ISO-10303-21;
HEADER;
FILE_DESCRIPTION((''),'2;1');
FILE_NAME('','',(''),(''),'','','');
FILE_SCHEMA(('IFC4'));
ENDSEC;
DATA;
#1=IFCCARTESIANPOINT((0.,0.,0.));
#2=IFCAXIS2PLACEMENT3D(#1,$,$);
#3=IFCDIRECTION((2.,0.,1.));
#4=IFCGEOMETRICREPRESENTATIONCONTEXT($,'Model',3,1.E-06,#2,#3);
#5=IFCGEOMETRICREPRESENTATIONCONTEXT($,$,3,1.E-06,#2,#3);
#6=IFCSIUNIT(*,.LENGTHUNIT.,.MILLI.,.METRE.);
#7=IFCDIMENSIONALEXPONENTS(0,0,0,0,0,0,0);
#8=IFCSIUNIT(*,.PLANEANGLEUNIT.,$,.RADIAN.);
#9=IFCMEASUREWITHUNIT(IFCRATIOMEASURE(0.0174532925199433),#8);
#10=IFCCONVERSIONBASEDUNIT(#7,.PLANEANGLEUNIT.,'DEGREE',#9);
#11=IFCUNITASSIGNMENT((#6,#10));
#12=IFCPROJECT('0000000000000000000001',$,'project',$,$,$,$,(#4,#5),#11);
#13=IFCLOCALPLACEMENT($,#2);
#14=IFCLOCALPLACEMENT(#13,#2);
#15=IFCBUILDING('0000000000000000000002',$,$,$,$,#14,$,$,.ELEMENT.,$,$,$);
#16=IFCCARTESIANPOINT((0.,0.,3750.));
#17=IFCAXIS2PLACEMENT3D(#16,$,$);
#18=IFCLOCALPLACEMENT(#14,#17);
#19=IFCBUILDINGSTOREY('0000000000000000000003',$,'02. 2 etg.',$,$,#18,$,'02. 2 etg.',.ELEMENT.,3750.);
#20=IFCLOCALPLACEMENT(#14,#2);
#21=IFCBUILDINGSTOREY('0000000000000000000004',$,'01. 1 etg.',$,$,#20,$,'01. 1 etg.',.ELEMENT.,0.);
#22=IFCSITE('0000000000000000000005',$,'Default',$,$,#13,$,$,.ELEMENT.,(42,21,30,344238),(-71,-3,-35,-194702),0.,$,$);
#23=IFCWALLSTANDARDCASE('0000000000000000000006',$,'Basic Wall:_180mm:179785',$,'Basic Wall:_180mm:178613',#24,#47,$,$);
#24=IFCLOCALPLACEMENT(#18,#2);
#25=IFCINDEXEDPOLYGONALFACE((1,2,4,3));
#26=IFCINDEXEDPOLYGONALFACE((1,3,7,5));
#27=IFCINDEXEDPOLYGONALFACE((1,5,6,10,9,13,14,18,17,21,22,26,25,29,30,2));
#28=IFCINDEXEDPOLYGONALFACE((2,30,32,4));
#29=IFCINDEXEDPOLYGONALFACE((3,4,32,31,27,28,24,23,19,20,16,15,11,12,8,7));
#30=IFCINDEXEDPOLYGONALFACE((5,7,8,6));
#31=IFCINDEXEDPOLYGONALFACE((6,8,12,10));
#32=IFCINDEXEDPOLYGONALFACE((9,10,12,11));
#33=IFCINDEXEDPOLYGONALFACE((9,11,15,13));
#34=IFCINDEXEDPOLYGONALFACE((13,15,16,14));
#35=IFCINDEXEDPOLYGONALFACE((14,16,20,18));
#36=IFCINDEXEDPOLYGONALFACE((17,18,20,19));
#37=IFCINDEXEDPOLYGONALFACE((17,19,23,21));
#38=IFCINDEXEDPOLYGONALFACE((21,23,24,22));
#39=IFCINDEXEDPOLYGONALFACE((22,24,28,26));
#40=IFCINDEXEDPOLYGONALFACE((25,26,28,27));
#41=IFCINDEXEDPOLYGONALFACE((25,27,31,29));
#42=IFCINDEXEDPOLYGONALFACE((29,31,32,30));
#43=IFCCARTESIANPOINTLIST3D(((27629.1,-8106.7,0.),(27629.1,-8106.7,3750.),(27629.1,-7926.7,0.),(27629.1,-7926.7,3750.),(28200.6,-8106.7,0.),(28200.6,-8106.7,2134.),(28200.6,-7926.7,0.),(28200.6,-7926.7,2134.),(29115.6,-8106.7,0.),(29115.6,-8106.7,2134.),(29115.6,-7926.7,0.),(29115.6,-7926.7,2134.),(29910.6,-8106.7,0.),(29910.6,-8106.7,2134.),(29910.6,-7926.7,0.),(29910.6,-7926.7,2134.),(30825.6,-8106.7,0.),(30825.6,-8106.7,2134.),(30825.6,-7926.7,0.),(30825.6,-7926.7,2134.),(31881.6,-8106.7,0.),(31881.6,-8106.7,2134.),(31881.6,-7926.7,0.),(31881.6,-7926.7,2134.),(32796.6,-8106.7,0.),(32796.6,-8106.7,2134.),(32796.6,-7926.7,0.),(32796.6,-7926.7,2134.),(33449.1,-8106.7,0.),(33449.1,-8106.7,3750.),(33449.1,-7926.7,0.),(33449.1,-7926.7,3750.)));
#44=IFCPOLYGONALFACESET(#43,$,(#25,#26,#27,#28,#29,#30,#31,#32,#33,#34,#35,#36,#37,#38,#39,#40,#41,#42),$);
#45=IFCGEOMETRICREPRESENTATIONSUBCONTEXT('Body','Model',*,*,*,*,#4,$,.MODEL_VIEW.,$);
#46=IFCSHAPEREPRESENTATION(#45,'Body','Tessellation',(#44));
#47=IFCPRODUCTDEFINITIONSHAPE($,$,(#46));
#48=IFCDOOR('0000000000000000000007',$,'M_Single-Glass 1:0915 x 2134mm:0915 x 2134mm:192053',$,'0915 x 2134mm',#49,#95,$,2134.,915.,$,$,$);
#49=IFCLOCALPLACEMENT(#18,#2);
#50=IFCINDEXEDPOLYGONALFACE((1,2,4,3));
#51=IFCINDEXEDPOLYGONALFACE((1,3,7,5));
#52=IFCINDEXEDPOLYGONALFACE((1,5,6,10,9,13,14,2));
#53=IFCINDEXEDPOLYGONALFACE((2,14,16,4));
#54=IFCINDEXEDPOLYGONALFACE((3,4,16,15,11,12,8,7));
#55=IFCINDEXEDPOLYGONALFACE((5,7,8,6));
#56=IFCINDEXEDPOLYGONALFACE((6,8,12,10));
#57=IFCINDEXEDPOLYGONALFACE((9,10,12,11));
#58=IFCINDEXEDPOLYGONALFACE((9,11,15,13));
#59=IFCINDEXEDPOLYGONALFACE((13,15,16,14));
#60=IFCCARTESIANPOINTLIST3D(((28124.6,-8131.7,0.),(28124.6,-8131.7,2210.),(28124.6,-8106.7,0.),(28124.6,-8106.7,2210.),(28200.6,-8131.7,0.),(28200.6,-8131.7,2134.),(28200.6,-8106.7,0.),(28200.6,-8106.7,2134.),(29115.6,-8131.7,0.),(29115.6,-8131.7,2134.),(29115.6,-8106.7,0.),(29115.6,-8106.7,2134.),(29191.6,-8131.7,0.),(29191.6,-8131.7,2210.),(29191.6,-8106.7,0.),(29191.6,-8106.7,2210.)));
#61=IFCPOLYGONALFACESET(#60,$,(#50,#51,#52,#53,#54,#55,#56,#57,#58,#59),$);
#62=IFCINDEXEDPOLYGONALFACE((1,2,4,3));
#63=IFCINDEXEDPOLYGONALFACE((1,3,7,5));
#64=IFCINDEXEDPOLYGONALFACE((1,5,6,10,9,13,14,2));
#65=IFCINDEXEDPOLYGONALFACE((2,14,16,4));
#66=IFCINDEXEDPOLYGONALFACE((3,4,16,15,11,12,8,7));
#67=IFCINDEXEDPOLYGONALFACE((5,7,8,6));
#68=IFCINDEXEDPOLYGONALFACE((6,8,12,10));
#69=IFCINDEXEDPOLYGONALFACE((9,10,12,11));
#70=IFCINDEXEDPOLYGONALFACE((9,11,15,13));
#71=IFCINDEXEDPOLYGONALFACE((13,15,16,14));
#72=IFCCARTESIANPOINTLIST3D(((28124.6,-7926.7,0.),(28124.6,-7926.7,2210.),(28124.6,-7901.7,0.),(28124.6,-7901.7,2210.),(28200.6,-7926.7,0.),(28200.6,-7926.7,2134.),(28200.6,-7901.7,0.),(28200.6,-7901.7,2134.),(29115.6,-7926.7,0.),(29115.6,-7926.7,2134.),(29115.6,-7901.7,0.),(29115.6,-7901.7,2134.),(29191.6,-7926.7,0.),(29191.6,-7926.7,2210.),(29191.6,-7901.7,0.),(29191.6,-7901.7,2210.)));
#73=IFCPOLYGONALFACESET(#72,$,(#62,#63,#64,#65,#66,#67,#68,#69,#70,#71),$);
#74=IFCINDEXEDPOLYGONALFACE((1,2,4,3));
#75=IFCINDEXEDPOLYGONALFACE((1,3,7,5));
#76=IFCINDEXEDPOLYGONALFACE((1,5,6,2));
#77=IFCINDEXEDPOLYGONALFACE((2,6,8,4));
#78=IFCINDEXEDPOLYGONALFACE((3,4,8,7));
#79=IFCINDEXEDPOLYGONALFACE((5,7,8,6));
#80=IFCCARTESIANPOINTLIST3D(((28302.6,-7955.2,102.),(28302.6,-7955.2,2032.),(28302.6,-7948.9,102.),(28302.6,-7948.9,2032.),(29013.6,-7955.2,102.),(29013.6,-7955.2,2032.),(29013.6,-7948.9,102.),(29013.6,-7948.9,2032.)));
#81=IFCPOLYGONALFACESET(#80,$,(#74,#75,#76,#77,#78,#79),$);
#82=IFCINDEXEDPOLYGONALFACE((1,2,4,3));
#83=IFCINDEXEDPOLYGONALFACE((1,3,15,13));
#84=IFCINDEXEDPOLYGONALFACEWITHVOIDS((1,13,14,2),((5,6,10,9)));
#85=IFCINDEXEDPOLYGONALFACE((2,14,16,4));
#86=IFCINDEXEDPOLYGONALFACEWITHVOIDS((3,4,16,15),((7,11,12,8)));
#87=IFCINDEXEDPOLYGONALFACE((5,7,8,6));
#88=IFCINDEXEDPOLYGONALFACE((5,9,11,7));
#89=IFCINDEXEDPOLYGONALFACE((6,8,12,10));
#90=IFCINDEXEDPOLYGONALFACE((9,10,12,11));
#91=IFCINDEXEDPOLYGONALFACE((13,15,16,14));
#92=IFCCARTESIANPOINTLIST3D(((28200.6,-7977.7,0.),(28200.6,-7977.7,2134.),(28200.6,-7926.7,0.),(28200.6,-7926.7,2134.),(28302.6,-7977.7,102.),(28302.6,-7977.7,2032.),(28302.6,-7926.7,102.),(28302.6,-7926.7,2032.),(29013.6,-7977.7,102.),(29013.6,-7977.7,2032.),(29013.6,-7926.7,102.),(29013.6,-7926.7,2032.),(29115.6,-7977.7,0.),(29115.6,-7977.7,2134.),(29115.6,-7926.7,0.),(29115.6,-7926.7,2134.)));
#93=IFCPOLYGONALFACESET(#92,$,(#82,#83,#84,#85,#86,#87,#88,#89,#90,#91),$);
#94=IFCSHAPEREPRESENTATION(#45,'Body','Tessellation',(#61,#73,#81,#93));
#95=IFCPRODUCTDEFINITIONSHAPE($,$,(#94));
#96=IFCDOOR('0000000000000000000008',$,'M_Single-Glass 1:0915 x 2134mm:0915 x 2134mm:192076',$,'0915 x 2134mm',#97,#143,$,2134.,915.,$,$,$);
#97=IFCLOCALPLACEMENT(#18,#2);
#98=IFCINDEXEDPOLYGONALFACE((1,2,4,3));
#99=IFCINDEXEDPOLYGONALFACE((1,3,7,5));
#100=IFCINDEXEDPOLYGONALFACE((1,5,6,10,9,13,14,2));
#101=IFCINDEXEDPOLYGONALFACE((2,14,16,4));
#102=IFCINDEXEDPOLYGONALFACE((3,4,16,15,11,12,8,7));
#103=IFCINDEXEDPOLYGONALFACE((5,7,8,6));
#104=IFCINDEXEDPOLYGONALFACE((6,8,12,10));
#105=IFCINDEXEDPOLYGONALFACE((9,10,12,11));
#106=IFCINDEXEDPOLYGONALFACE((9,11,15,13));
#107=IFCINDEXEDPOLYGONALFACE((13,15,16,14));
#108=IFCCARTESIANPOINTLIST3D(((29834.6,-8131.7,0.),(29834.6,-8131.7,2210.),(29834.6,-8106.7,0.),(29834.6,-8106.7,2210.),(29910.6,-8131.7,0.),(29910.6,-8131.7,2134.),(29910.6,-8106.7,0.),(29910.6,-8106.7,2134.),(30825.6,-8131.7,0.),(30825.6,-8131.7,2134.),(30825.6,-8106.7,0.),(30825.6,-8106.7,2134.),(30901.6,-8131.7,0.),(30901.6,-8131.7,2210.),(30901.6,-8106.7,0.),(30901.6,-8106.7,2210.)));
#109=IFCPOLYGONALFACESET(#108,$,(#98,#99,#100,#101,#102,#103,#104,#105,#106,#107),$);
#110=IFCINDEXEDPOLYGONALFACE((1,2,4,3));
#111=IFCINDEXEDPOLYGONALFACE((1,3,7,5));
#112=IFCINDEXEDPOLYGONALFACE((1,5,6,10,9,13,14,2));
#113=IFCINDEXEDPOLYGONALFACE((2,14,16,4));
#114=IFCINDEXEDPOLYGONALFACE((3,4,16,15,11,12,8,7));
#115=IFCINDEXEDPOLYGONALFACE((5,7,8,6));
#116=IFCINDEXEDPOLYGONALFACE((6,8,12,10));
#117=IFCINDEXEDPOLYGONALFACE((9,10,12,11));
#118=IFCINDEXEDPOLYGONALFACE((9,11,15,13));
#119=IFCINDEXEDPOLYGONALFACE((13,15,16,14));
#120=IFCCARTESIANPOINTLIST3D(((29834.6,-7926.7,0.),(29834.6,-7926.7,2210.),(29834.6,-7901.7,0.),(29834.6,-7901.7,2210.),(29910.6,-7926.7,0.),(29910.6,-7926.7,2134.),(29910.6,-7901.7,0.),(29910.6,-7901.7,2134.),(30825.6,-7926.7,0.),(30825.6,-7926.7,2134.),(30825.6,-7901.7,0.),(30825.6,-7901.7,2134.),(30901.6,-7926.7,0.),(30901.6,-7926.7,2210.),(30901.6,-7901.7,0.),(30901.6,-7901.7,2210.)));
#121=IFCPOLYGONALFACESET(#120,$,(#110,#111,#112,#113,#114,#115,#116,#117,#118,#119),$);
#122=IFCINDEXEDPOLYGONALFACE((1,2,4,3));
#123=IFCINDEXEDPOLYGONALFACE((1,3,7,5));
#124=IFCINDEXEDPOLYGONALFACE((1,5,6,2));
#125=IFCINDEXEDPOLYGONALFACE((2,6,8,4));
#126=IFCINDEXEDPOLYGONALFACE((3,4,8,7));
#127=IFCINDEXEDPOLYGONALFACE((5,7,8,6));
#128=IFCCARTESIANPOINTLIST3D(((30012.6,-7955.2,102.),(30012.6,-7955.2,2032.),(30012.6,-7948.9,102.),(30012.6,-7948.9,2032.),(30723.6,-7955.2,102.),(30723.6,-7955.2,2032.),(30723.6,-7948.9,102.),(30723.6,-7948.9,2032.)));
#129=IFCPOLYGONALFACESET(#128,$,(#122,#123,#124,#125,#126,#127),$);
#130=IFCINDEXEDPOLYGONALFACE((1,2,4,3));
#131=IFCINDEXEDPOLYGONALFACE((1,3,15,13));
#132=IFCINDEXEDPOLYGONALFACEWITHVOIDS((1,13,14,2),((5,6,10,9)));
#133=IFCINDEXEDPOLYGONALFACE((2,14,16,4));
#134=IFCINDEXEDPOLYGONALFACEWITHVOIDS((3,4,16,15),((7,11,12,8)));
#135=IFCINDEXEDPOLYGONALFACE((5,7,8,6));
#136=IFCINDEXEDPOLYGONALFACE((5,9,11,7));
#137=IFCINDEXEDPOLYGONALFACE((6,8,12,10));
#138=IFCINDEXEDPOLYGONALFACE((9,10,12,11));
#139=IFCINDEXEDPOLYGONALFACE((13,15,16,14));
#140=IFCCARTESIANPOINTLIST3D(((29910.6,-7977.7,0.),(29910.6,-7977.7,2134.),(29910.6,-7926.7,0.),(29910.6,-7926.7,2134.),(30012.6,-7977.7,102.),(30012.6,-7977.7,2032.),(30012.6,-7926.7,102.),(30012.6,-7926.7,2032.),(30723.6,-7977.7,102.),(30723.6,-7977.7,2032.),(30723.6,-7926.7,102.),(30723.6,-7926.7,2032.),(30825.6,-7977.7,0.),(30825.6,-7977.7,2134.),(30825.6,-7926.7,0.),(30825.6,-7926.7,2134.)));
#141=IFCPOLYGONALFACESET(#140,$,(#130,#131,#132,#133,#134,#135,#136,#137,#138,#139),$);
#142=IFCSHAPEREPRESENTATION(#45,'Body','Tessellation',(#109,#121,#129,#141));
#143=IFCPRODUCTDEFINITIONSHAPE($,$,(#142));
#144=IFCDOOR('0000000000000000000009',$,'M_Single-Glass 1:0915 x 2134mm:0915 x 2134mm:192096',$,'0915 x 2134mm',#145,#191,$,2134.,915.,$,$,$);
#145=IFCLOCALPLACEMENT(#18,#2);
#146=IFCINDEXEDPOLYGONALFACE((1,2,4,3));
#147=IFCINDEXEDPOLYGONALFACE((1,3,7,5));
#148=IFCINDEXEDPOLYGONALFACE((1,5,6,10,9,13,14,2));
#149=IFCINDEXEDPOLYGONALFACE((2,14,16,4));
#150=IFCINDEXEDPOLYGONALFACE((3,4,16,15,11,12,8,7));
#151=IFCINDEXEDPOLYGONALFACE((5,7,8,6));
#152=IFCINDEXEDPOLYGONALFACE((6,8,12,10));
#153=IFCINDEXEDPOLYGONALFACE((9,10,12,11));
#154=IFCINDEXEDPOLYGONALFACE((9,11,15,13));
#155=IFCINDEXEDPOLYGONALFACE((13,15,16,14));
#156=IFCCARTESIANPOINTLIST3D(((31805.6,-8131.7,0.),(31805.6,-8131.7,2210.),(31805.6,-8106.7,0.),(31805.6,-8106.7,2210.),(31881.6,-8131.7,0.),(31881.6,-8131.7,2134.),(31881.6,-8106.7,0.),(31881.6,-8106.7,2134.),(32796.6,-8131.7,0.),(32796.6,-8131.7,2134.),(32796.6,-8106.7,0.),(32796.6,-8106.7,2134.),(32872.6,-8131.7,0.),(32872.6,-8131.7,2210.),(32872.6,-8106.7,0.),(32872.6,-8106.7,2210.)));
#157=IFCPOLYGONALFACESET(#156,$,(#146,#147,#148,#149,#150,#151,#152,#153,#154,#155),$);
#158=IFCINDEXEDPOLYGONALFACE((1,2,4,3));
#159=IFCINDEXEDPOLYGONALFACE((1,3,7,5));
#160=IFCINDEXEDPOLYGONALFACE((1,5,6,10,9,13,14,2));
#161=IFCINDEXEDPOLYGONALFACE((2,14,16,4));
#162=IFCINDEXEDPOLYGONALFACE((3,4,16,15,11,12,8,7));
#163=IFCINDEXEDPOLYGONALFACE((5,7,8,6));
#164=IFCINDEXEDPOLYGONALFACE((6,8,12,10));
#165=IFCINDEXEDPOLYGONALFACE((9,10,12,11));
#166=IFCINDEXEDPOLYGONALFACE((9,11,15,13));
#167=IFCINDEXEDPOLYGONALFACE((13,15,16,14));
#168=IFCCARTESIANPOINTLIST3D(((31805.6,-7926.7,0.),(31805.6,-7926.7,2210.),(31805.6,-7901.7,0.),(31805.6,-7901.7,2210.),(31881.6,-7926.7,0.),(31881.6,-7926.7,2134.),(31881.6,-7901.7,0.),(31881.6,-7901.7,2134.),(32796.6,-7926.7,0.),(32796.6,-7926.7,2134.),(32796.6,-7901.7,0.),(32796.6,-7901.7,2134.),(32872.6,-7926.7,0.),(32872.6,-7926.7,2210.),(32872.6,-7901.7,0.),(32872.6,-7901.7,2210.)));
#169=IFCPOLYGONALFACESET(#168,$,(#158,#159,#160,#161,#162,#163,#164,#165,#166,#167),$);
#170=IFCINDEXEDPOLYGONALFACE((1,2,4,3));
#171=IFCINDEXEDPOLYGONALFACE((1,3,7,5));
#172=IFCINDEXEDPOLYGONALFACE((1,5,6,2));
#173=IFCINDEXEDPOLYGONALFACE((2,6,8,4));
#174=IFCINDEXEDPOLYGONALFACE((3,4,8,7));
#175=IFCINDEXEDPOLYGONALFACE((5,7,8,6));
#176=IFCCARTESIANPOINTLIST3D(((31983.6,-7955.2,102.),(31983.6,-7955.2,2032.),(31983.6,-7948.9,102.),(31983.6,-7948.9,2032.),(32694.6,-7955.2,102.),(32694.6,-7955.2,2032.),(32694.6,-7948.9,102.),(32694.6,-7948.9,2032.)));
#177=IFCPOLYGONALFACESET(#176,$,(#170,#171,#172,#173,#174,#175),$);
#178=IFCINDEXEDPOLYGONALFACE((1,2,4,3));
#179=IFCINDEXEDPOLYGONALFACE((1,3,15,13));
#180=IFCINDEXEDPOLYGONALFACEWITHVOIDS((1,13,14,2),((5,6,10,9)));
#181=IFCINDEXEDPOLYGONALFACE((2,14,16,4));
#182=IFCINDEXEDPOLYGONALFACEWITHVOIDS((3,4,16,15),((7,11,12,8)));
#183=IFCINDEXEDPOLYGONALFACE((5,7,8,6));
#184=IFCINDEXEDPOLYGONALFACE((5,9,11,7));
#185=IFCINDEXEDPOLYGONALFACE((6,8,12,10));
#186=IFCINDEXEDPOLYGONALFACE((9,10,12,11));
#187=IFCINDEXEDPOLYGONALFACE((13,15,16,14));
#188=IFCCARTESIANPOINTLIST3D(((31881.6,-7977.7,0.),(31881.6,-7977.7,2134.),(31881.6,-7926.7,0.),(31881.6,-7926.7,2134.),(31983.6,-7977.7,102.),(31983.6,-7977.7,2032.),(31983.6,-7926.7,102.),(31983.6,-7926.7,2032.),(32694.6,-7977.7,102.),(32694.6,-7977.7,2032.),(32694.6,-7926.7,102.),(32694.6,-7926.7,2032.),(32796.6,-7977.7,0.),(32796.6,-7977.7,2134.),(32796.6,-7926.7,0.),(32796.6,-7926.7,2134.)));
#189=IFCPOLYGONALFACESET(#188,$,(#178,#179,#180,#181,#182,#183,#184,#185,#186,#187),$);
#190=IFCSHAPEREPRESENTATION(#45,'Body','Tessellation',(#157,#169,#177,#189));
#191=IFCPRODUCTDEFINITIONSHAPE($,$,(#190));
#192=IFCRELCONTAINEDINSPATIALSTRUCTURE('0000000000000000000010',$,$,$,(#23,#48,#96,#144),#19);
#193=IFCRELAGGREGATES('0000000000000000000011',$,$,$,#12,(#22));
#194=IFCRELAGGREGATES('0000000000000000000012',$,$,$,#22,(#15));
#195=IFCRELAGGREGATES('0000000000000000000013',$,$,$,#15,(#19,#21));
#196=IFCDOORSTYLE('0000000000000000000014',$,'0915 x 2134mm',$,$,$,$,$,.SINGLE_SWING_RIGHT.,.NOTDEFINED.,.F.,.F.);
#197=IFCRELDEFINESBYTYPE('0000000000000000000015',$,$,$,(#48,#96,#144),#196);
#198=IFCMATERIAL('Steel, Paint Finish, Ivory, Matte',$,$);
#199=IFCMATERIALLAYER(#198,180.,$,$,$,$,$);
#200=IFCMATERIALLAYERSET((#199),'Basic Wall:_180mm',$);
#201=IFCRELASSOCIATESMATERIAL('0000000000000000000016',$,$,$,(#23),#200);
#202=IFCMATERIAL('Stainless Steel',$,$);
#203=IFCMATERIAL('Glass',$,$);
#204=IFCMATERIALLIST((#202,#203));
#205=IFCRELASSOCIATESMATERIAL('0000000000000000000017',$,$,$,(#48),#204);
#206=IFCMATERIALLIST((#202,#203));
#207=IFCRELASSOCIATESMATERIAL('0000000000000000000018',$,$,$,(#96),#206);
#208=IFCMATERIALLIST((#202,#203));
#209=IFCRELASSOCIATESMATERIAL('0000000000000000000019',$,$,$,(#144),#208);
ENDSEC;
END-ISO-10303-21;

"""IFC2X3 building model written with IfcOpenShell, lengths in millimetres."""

from ifc_helpers import new_model, entity, si_unit, converted_unit, direction, frame, frame_2d, origin, place, context, subcontext, project, spatial, polyline, rectangle, outline, extrude, source, transform, mapped, material, material_list, layer, layer_set, layer_usage, type_object, type_shapes, element, fill, save


model = new_model("IFC2X3")

# Units and contexts
model_context = context("Model", 3, precision=1e-06, world=origin(), true_north=direction((2.0, 0.0, 1.0)))
context_of_model = context(None, 3, precision=1e-06, world=origin(), true_north=direction((2.0, 0.0, 1.0)))
body_context = subcontext(model_context, "Body", "Model", "MODEL_VIEW")
ifc_project = project(units=[si_unit("LENGTHUNIT", "METRE", prefix="MILLI"), converted_unit("PLANEANGLEUNIT", "DEGREE", entity("IfcRatioMeasure", 0.0174532925199433), si_unit("PLANEANGLEUNIT", "RADIAN"), dimensions=[0, 0, 0, 0, 0, 0, 0])], contexts=[model_context, context_of_model])

# Site, building, storey
site_placement = place(None, origin())
site = spatial("IfcSite", under=ifc_project, at=site_placement, Name="Default", CompositionType="ELEMENT", RefLatitude=(42, 21, 30, 344238), RefLongitude=(-71, -3, -35, -194702), RefElevation=0.0)
building_placement = place(site_placement, origin())
building = spatial("IfcBuilding", under=site, at=building_placement, CompositionType="ELEMENT")
storey_1_placement = place(building_placement, frame((0.0, 0.0, 3750.0)))
storey_1 = spatial("IfcBuildingStorey", under=building, at=storey_1_placement, Name="02. 2 etg.", LongName="02. 2 etg.", CompositionType="ELEMENT", Elevation=3750.0)

# Shared definitions
ifc_material_1 = material(Name="Steel, Paint Finish, Ivory, Matte")
ifc_material_2 = material(Name="Stainless Steel")
ifc_material_3 = material(Name="Glass")

# Shared definitions
ifc_layer_1 = layer(ifc_material_1, 180.0)
ifc_layer_set_1 = layer_set([ifc_layer_1], Name="Basic Wall:_180mm")

# Wall, openings, doors
ifc_layer_usage_1 = layer_usage(ifc_layer_set_1, "AXIS2", "POSITIVE", -90.0)
wall_1_placement = place(storey_1_placement, frame((27629.1, -8016.7, 0.0)))
wall_1 = element("IfcWallStandardCase", 1, at=wall_1_placement, inside=storey_1, material=ifc_layer_usage_1, Name="Basic Wall:_180mm:179785", ObjectType="Basic Wall:_180mm:178613", context=body_context, shape_type="SweptSolid", body=[
    extrude(rectangle(XDim=5820.0, YDim=180.0, at=frame_2d((2910.0, 0.0), x_axis=(-1.0, 0.0))), origin(), (0.0, 0.0, 1.0), 3750.0),
])
opening_1_placement = place(wall_1_placement, frame((571.5, -90.0, 0.0)))
opening_1 = element("IfcOpeningElement", 2, at=opening_1_placement, cuts=wall_1, ObjectType="Opening", context=body_context, shape_type="SweptSolid", body=[
    extrude(rectangle(XDim=915.0, YDim=2134.0, at=frame_2d((1067.0, 457.5), x_axis=(0.0, 1.0))), frame((0.0, 0.0, 0.0), z_axis=(0.0, 1.0, 0.0), x_axis=(0.0, 0.0, 1.0)), (0.0, 0.0, 1.0), 180.0),
])
opening_2_placement = place(wall_1_placement, frame((2281.5, -90.0, 0.0)))
opening_2 = element("IfcOpeningElement", 3, at=opening_2_placement, cuts=wall_1, ObjectType="Opening", context=body_context, shape_type="SweptSolid", body=[
    extrude(rectangle(XDim=915.0, YDim=2134.0, at=frame_2d((1067.0, 457.5), x_axis=(0.0, 1.0))), frame((0.0, 0.0, 0.0), z_axis=(0.0, 1.0, 0.0), x_axis=(0.0, 0.0, 1.0)), (0.0, 0.0, 1.0), 180.0),
])
opening_3_placement = place(wall_1_placement, frame((4252.5, -90.0, 0.0)))
opening_3 = element("IfcOpeningElement", 4, at=opening_3_placement, cuts=wall_1, ObjectType="Opening", context=body_context, shape_type="SweptSolid", body=[
    extrude(rectangle(XDim=915.0, YDim=2134.0, at=frame_2d((1067.0, 457.5), x_axis=(0.0, 1.0))), frame((0.0, 0.0, 0.0), z_axis=(0.0, 1.0, 0.0), x_axis=(0.0, 0.0, 1.0)), (0.0, 0.0, 1.0), 180.0),
])
ifc_material_list_1 = material_list([ifc_material_2, ifc_material_3])
door_style_1 = type_object("IfcDoorStyle", Name="0915 x 2134mm", ConstructionType="NOTDEFINED", OperationType="SINGLE_SWING_RIGHT", ParameterTakesPrecedence=False, Sizeable=False)
shared_shape_1 = source(origin(), body_context, "Body", "SweptSolid", [
    extrude(outline(polyline([(-457.5, -1048.0), (-457.5, 1086.0), (-533.5, 1086.0), (-533.5, -1124.0), (533.5, -1124.0), (533.5, 1086.0), (457.5, 1086.0), (457.5, -1048.0), (-457.5, -1048.0)])), frame((457.5, -25.0, 1086.0), z_axis=(0.0, -1.0, 0.0), x_axis=(-1.0, 0.0, 0.0)), (0.0, 0.0, -1.0), 25.0),
    extrude(outline(polyline([(-457.5, -1048.0), (-457.5, 1086.0), (-533.5, 1086.0), (-533.5, -1124.0), (533.5, -1124.0), (533.5, 1086.0), (457.5, 1086.0), (457.5, -1048.0), (-457.5, -1048.0)])), frame((457.5, 180.0, 1086.0), z_axis=(0.0, -1.0, 0.0), x_axis=(-1.0, 0.0, 0.0)), (0.0, 0.0, -1.0), 25.0),
    extrude(rectangle(XDim=6.3, YDim=711.0, at=frame_2d((0.0, 0.0), x_axis=(1.0, 0.0))), frame((457.5, 154.6, 102.0), z_axis=(0.0, 0.0, 1.0), x_axis=(0.0, 1.0, 0.0)), (0.0, 0.0, 1.0), 1930.0),
    extrude(outline(polyline([(-1067.0, -457.5), (1067.0, -457.5), (1067.0, 457.5), (-1067.0, 457.5), (-1067.0, -457.5)]), holes=[polyline([(-965.0, 355.5), (965.0, 355.5), (965.0, -355.5), (-965.0, -355.5), (-965.0, 355.5)])]), frame((457.5, 129.0, 1067.0), z_axis=(0.0, 1.0, 0.0), x_axis=(0.0, 0.0, -1.0)), (0.0, 0.0, 1.0), 51.0),
])
type_shapes(door_style_1, [shared_shape_1])
door_1_placement = place(opening_1_placement, origin())
door_1 = element("IfcDoor", 5, at=door_1_placement, inside=storey_1, type_object=door_style_1, material=ifc_material_list_1, Name="M_Single-Glass 1:0915 x 2134mm:0915 x 2134mm:192053", ObjectType="0915 x 2134mm", OverallHeight=2134.0, OverallWidth=915.0, context=body_context, shape_type="MappedRepresentation", body=[
    mapped(shared_shape_1, transform((0.0, 0.0, 0.0), scale=1.0)),
])
fill(opening_1, door_1)
ifc_material_list_2 = material_list([ifc_material_2, ifc_material_3])
door_2_placement = place(opening_2_placement, origin())
door_2 = element("IfcDoor", 6, at=door_2_placement, inside=storey_1, type_object=door_style_1, material=ifc_material_list_2, Name="M_Single-Glass 1:0915 x 2134mm:0915 x 2134mm:192076", ObjectType="0915 x 2134mm", OverallHeight=2134.0, OverallWidth=915.0, context=body_context, shape_type="MappedRepresentation", body=[
    mapped(shared_shape_1, transform((0.0, 0.0, 0.0), scale=1.0)),
])
fill(opening_2, door_2)
ifc_material_list_3 = material_list([ifc_material_2, ifc_material_3])
door_3_placement = place(opening_3_placement, origin())
door_3 = element("IfcDoor", 7, at=door_3_placement, inside=storey_1, type_object=door_style_1, material=ifc_material_list_3, Name="M_Single-Glass 1:0915 x 2134mm:0915 x 2134mm:192096", ObjectType="0915 x 2134mm", OverallHeight=2134.0, OverallWidth=915.0, context=body_context, shape_type="MappedRepresentation", body=[
    mapped(shared_shape_1, transform((0.0, 0.0, 0.0), scale=1.0)),
])
fill(opening_3, door_3)

# Shared definitions
storey_2_placement = place(building_placement, origin())
storey_2 = spatial("IfcBuildingStorey", under=building, at=storey_2_placement, Name="01. 1 etg.", LongName="01. 1 etg.", CompositionType="ELEMENT", Elevation=0.0)

save(model, "model.ifc")
